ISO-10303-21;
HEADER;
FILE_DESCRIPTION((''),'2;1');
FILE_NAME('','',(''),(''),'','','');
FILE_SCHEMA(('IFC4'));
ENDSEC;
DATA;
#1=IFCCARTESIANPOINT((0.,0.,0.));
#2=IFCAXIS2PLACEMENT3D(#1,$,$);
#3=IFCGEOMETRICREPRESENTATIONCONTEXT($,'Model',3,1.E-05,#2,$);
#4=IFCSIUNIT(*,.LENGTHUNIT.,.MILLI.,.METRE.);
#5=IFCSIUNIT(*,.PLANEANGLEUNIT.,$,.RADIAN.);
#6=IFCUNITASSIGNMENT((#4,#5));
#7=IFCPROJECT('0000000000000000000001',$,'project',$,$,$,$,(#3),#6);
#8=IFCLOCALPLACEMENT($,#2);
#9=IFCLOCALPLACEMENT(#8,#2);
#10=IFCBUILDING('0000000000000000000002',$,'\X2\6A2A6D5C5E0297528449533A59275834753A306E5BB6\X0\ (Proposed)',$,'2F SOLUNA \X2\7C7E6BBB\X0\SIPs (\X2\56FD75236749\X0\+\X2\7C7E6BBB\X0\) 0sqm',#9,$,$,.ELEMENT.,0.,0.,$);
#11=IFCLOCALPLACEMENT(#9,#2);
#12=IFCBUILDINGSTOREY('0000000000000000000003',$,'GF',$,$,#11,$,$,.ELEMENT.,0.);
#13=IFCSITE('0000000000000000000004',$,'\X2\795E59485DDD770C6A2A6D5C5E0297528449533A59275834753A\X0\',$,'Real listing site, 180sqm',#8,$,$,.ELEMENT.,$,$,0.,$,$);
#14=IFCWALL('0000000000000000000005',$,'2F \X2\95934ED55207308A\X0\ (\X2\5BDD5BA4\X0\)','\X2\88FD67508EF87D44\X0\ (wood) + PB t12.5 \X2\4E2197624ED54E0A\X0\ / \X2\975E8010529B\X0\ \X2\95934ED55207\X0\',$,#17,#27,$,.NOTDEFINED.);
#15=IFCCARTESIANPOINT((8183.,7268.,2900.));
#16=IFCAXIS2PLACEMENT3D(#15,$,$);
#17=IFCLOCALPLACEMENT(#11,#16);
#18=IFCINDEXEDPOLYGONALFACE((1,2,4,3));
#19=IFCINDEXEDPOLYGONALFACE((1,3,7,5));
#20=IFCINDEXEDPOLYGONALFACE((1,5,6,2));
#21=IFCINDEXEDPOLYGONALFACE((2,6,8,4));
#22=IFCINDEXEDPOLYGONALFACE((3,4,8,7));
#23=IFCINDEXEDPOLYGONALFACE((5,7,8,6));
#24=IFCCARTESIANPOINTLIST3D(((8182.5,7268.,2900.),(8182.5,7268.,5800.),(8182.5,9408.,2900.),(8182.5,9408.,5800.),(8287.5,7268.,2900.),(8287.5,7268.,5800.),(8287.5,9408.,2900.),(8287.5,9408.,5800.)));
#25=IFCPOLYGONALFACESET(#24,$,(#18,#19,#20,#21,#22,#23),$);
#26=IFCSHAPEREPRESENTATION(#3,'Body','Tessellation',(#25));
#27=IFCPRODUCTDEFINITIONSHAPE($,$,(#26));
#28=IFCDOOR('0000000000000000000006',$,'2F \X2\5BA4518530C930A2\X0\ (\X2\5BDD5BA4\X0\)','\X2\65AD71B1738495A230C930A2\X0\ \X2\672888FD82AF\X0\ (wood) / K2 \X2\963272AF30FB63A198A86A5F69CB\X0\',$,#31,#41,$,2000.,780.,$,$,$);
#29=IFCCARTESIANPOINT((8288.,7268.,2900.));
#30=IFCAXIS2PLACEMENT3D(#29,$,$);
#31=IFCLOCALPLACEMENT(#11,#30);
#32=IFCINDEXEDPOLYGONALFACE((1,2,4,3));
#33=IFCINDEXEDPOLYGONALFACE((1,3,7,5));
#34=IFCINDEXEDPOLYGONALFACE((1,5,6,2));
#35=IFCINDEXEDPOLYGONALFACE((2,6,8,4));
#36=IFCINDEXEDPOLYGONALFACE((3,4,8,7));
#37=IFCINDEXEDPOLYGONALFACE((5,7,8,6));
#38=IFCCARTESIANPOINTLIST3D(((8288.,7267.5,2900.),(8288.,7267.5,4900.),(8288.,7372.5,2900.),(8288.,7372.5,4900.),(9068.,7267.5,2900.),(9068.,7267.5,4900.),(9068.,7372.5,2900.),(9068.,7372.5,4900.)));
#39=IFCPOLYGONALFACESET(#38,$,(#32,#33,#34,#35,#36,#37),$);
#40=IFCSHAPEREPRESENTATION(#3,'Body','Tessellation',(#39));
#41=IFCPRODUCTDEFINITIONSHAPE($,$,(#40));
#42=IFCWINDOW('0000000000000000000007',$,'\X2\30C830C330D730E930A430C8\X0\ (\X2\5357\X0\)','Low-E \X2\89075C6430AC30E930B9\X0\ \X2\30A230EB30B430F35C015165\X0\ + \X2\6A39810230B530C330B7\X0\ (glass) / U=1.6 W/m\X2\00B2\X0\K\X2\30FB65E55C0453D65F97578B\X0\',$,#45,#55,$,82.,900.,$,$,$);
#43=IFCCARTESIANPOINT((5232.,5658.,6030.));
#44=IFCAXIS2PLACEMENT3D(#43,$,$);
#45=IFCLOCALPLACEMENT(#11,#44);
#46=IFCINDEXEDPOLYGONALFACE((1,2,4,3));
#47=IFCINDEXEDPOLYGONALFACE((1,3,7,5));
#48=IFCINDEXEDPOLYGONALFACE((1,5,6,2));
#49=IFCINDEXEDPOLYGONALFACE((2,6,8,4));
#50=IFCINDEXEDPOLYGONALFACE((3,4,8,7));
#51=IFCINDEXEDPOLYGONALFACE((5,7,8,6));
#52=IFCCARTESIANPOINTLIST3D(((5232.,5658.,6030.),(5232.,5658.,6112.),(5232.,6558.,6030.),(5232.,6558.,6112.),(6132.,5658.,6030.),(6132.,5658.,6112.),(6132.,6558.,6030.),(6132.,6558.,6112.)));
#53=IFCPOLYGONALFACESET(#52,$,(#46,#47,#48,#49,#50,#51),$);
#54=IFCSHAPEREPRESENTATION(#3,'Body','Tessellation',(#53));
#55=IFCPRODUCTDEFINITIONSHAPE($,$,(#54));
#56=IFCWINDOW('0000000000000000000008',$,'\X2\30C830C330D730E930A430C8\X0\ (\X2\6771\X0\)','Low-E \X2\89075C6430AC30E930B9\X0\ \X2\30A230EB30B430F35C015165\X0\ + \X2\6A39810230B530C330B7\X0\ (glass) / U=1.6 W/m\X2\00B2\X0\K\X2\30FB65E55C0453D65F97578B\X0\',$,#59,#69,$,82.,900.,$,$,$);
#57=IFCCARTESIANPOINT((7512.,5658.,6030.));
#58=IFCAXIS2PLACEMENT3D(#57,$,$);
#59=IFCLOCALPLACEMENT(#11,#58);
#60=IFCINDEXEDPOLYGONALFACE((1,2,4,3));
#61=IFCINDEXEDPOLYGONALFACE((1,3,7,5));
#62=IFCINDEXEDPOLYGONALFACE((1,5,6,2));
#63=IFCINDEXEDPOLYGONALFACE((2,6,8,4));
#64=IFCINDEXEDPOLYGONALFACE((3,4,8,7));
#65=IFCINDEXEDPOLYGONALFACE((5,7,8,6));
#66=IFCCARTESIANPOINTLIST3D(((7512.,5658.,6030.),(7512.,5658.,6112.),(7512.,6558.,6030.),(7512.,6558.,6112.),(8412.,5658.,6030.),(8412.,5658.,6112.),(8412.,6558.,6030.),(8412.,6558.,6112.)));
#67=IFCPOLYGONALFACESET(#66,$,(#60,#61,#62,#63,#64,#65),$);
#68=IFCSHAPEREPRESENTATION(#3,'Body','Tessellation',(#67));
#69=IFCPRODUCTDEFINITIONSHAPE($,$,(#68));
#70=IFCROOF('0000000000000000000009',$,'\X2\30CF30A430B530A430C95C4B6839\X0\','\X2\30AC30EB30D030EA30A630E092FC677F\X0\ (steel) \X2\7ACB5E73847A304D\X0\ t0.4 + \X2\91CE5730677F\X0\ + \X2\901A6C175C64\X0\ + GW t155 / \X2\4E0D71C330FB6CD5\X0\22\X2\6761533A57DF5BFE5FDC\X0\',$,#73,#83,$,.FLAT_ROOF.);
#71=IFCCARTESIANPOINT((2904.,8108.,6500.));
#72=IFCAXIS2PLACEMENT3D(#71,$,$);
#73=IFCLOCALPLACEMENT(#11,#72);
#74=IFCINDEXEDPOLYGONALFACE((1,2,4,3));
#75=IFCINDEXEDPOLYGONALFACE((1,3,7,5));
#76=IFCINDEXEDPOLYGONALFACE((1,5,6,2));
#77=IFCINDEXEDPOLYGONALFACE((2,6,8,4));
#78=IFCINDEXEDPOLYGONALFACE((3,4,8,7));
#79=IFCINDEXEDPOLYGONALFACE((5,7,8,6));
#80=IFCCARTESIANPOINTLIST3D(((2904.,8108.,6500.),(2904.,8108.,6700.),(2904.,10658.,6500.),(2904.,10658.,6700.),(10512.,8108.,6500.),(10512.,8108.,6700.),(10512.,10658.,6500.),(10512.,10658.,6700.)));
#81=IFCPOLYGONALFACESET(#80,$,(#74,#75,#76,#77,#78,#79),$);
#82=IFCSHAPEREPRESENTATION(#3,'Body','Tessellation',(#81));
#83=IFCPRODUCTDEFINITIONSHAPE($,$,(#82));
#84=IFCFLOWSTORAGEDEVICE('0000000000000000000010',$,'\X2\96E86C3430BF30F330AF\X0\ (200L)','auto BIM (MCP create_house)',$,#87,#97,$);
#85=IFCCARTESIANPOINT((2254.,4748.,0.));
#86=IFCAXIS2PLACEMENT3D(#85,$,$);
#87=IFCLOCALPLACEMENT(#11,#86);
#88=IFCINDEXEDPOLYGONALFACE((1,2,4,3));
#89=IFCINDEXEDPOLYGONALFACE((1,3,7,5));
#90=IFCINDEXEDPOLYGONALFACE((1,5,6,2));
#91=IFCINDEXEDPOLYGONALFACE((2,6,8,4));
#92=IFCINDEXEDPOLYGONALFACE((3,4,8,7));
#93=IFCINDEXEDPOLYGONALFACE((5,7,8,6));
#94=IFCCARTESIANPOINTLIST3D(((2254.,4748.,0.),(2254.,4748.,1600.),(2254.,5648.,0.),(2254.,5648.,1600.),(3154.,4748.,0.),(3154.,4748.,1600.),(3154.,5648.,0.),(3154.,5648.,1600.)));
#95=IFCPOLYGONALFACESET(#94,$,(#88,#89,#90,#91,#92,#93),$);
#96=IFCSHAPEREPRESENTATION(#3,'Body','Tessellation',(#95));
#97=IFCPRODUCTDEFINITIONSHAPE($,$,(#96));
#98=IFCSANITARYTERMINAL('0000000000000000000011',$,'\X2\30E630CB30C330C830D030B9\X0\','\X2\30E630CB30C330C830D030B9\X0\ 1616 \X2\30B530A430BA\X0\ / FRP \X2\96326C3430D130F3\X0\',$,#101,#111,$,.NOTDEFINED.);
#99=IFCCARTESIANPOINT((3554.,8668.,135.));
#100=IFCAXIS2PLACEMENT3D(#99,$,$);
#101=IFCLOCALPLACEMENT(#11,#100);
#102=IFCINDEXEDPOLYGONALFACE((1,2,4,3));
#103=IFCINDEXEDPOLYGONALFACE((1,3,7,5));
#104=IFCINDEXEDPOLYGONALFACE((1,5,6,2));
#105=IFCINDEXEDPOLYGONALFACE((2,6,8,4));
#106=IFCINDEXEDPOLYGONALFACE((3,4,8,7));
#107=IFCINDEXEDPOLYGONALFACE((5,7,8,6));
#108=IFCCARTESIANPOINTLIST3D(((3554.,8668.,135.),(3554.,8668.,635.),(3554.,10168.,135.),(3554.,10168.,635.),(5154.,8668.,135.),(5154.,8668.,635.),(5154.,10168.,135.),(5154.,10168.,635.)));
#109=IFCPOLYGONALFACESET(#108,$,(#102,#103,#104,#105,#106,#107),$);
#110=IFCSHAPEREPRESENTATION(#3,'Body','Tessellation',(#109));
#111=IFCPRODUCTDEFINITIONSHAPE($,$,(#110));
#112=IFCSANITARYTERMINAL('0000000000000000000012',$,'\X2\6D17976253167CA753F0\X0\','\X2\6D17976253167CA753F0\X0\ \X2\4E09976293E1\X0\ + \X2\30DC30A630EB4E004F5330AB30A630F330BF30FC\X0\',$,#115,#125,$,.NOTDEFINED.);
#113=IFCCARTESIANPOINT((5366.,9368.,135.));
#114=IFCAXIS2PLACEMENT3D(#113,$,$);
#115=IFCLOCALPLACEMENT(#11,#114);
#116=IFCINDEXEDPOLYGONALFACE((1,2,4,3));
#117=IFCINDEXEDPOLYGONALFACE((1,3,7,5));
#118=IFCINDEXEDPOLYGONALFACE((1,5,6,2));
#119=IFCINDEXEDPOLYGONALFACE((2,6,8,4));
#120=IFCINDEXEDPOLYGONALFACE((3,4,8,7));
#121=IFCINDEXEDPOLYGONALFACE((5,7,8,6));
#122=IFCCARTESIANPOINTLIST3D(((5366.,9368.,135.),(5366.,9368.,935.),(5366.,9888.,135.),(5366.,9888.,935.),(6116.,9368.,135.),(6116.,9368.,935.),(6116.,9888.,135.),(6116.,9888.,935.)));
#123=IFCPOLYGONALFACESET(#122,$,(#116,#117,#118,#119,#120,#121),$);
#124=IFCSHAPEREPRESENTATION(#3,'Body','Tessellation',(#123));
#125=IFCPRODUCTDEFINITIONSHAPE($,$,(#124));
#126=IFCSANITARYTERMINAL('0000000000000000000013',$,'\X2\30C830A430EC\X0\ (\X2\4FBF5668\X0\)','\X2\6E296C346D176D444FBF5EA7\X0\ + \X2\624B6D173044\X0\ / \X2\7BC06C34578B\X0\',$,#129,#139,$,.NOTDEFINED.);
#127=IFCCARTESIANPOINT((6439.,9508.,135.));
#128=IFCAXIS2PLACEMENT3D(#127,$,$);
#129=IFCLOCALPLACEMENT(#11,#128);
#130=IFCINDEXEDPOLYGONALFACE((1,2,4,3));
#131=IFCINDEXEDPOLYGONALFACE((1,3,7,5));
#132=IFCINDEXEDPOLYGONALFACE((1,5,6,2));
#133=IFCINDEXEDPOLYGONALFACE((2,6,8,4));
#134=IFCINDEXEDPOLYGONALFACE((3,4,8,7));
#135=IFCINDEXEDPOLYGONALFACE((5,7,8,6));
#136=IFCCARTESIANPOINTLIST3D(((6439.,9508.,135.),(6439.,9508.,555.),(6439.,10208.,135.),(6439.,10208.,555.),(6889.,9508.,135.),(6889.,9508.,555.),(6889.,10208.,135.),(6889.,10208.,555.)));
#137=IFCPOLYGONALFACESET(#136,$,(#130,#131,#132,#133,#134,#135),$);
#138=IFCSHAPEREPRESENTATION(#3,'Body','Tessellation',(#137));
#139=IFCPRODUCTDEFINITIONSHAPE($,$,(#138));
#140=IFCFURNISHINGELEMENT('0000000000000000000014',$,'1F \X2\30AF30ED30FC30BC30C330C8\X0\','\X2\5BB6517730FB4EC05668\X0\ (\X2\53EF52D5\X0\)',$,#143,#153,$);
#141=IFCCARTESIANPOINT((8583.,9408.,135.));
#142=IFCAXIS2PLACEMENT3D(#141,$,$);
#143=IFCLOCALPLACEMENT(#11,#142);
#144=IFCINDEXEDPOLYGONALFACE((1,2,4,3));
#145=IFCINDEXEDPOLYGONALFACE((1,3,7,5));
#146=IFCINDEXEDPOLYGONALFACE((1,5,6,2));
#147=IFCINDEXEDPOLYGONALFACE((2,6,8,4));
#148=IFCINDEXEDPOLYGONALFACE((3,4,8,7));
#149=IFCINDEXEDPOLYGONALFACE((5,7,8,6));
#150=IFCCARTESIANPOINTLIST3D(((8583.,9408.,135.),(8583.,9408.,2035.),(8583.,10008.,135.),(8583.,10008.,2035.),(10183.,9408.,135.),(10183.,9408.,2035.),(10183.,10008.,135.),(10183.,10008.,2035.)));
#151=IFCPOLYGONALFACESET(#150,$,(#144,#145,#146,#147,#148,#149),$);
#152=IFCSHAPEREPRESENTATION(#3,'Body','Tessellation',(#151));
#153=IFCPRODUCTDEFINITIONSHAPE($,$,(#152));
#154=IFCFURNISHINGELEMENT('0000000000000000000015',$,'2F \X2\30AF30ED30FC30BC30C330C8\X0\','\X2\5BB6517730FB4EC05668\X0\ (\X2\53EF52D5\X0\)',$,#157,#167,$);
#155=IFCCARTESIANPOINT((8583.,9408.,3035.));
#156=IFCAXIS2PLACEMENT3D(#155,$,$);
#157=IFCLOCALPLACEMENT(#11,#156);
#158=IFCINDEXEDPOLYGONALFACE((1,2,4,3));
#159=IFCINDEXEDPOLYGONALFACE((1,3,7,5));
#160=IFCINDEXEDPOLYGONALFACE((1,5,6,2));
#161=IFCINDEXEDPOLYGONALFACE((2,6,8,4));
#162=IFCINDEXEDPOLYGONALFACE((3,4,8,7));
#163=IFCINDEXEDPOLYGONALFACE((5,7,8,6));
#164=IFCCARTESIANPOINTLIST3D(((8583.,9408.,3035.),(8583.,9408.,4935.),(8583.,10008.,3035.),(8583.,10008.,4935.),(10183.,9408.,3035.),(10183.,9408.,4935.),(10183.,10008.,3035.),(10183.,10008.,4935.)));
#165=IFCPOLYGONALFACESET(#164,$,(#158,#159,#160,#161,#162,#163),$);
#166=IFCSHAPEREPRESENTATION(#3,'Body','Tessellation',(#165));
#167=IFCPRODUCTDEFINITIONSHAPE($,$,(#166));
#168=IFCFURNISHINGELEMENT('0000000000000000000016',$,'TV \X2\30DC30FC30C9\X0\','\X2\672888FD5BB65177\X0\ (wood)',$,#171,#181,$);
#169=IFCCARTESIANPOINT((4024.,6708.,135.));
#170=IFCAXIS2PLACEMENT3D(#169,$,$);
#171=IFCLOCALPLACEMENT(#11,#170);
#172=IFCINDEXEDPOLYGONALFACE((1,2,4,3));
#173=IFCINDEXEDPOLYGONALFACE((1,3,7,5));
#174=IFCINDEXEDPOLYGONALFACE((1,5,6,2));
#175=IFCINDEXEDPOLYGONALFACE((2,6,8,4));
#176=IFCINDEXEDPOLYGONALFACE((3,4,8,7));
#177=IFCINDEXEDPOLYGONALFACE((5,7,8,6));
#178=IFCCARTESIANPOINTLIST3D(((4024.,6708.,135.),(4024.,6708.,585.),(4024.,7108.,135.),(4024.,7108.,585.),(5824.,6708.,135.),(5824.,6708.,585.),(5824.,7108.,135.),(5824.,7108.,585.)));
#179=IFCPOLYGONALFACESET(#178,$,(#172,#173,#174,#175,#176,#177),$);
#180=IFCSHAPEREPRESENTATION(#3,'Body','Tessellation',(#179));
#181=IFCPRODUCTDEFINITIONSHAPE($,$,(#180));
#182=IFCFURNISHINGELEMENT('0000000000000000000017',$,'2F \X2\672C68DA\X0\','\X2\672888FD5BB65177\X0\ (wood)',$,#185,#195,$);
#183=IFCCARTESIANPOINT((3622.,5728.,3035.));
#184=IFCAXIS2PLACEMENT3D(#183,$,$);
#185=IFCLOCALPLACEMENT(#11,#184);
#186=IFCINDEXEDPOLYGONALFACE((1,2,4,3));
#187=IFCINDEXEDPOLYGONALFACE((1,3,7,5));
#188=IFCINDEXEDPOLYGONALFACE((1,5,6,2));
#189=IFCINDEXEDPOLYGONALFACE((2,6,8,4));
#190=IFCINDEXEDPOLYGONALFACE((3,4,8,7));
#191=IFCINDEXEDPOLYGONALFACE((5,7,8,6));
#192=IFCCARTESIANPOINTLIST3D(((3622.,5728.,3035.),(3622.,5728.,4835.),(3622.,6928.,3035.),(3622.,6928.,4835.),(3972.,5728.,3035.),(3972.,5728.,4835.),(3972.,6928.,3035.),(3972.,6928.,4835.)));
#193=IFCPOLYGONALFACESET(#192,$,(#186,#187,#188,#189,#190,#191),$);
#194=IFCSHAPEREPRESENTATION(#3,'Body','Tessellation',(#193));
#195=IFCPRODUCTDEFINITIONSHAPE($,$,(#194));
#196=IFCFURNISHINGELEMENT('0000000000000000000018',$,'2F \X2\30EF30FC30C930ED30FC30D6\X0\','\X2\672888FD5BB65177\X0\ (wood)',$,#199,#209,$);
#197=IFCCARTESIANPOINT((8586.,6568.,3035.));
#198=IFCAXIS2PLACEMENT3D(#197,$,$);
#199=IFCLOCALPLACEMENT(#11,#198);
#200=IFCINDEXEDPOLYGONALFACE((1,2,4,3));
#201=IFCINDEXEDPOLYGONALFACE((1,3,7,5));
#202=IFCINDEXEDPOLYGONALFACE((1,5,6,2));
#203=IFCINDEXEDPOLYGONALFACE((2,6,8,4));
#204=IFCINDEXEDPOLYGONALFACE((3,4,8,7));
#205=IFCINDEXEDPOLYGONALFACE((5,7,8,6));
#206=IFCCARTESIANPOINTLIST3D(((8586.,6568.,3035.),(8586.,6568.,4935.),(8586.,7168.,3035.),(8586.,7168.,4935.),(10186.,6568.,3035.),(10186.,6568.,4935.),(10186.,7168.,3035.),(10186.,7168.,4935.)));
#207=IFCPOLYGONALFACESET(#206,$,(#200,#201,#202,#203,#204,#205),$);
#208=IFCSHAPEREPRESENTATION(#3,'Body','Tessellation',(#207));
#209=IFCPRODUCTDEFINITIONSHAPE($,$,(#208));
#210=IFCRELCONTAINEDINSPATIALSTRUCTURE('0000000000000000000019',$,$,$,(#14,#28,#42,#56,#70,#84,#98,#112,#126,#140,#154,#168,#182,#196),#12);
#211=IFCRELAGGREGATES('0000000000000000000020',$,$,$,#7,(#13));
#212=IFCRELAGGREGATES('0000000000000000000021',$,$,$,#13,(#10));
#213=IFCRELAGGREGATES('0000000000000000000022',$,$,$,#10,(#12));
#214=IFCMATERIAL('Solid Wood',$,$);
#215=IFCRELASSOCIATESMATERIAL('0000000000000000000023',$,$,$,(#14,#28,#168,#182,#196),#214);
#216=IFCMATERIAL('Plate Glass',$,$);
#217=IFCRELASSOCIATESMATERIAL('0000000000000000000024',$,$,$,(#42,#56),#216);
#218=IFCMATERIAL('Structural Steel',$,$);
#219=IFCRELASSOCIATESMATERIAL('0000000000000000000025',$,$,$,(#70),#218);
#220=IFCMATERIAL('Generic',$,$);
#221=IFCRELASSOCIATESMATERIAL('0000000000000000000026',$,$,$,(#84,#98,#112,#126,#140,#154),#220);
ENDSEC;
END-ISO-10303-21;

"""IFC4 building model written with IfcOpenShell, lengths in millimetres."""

from ifc_helpers import new_model, si_unit, frame, frame_2d, origin, place, context, project, spatial, rectangle, extrude, material, element, save


model = new_model("IFC4")

# Units and contexts
model_context = context("Model", 3, precision=1e-05, world=origin())
ifc_project = project(units=[si_unit("LENGTHUNIT", "METRE", prefix="MILLI"), si_unit("PLANEANGLEUNIT", "RADIAN")], contexts=[model_context])

# Site, building, storey
site_placement = place(None, origin())
site = spatial("IfcSite", under=ifc_project, at=site_placement, Name="神奈川県横浜市青葉区大場町", ObjectType="Real listing site, 180sqm", CompositionType="ELEMENT", RefElevation=0.0)
building_placement = place(site_placement, origin())
building = spatial("IfcBuilding", under=site, at=building_placement, Name="横浜市青葉区大場町の家 (Proposed)", ObjectType="2F SOLUNA 籾殻SIPs (国産杉+籾殻) 0sqm", CompositionType="ELEMENT", ElevationOfRefHeight=0.0, ElevationOfTerrain=0.0)
storey_placement = place(building_placement, origin())
storey = spatial("IfcBuildingStorey", under=building, at=storey_placement, Name="GF", CompositionType="ELEMENT", Elevation=0.0)

# Shared definitions
ifc_material_1 = material(Name="Solid Wood")
ifc_material_2 = material(Name="Plate Glass")

# Wall
wall_1_placement = place(storey_placement, frame((8183.0, 7268.0, 2900.0)))
element("IfcWall", 1, at=wall_1_placement, inside=storey, material=ifc_material_1, Name="2F 間仕切り (寝室)", Description="製材軸組 (wood) + PB t12.5 両面仕上 / 非耐力 間仕切", PredefinedType="NOTDEFINED", context=model_context, shape_type="SweptSolid", body=[
    extrude(rectangle(XDim=105.0, YDim=2140.0, at=frame_2d((52.0, 1070.0))), frame((8183.0, 7268.0, 2900.0)), (0.0, 0.0, 1.0), 2900.0),
])

# Door
door_1_placement = place(storey_placement, frame((8288.0, 7268.0, 2900.0)))
element("IfcDoor", 2, at=door_1_placement, inside=storey, material=ifc_material_1, Name="2F 室内ドア (寝室)", Description="断熱玄関ドア 木製芯 (wood) / K2 防犯・採風機構", OverallHeight=2000.0, OverallWidth=780.0, context=model_context, shape_type="SweptSolid", body=[
    extrude(rectangle(XDim=780.0, YDim=105.0, at=frame_2d((390.0, 52.0))), frame((8288.0, 7268.0, 2900.0)), (0.0, 0.0, 1.0), 2000.0),
])

# Windows
window_1_placement = place(storey_placement, frame((5232.0, 5658.0, 6030.0)))
element("IfcWindow", 3, at=window_1_placement, inside=storey, material=ifc_material_2, Name="トップライト (南)", Description="Low-E 複層ガラス アルゴン封入 + 樹脂サッシ (glass) / U=1.6 W/m²K・日射取得型", OverallHeight=82.0, OverallWidth=900.0, context=model_context, shape_type="SweptSolid", body=[
    extrude(rectangle(XDim=900.0, YDim=900.0, at=frame_2d((450.0, 450.0))), frame((5232.0, 5658.0, 6030.0)), (0.0, 0.0, 1.0), 82.0),
])
window_2_placement = place(storey_placement, frame((7512.0, 5658.0, 6030.0)))
element("IfcWindow", 4, at=window_2_placement, inside=storey, material=ifc_material_2, Name="トップライト (東)", Description="Low-E 複層ガラス アルゴン封入 + 樹脂サッシ (glass) / U=1.6 W/m²K・日射取得型", OverallHeight=82.0, OverallWidth=900.0, context=model_context, shape_type="SweptSolid", body=[
    extrude(rectangle(XDim=900.0, YDim=900.0, at=frame_2d((450.0, 450.0))), frame((7512.0, 5658.0, 6030.0)), (0.0, 0.0, 1.0), 82.0),
])

# Roof
ifc_material_3 = material(Name="Structural Steel")
roof_placement = place(storey_placement, frame((2904.0, 8108.0, 6500.0)))
element("IfcRoof", 5, at=roof_placement, inside=storey, material=ifc_material_3, Name="ハイサイド屋根", Description="ガルバリウム鋼板 (steel) 立平葺き t0.4 + 野地板 + 通気層 + GW t155 / 不燃・法22条区域対応", PredefinedType="FLAT_ROOF", context=model_context, shape_type="SweptSolid", body=[
    extrude(rectangle(XDim=7608.0, YDim=2550.0, at=frame_2d((3804.0, 1275.0))), frame((2904.0, 8108.0, 6500.0)), (0.0, 0.0, 1.0), 200.0),
])

# Flow storage device
ifc_material_4 = material(Name="Generic")
flow_storage_device_placement = place(storey_placement, frame((2254.0, 4748.0, 0.0)))
element("IfcFlowStorageDevice", 6, at=flow_storage_device_placement, inside=storey, material=ifc_material_4, Name="雨水タンク (200L)", Description="auto BIM (MCP create_house)", context=model_context, shape_type="SweptSolid", body=[
    extrude(rectangle(XDim=900.0, YDim=900.0, at=frame_2d((450.0, 450.0))), frame((2254.0, 4748.0, 0.0)), (0.0, 0.0, 1.0), 1600.0),
])

# Sanitary terminals
sanitary_terminal_1_placement = place(storey_placement, frame((3554.0, 8668.0, 135.0)))
element("IfcSanitaryTerminal", 7, at=sanitary_terminal_1_placement, inside=storey, material=ifc_material_4, Name="ユニットバス", Description="ユニットバス 1616 サイズ / FRP 防水パン", PredefinedType="NOTDEFINED", context=model_context, shape_type="SweptSolid", body=[
    extrude(rectangle(XDim=1600.0, YDim=1500.0, at=frame_2d((800.0, 750.0))), frame((3554.0, 8668.0, 135.0)), (0.0, 0.0, 1.0), 500.0),
])
sanitary_terminal_2_placement = place(storey_placement, frame((5366.0, 9368.0, 135.0)))
element("IfcSanitaryTerminal", 8, at=sanitary_terminal_2_placement, inside=storey, material=ifc_material_4, Name="洗面化粧台", Description="洗面化粧台 三面鏡 + ボウル一体カウンター", PredefinedType="NOTDEFINED", context=model_context, shape_type="SweptSolid", body=[
    extrude(rectangle(XDim=750.0, YDim=520.0, at=frame_2d((375.0, 260.0))), frame((5366.0, 9368.0, 135.0)), (0.0, 0.0, 1.0), 800.0),
])
sanitary_terminal_3_placement = place(storey_placement, frame((6439.0, 9508.0, 135.0)))
element("IfcSanitaryTerminal", 9, at=sanitary_terminal_3_placement, inside=storey, material=ifc_material_4, Name="トイレ (便器)", Description="温水洗浄便座 + 手洗い / 節水型", PredefinedType="NOTDEFINED", context=model_context, shape_type="SweptSolid", body=[
    extrude(rectangle(XDim=450.0, YDim=700.0, at=frame_2d((225.0, 350.0))), frame((6439.0, 9508.0, 135.0)), (0.0, 0.0, 1.0), 420.0),
])

# Furnishing elements
furnishing_1_placement = place(storey_placement, frame((8583.0, 9408.0, 135.0)))
element("IfcFurnishingElement", 10, at=furnishing_1_placement, inside=storey, material=ifc_material_4, Name="1F クローゼット", Description="家具・什器 (可動)", context=model_context, shape_type="SweptSolid", body=[
    extrude(rectangle(XDim=1600.0, YDim=600.0, at=frame_2d((800.0, 300.0))), frame((8583.0, 9408.0, 135.0)), (0.0, 0.0, 1.0), 1900.0),
])
furnishing_2_placement = place(storey_placement, frame((8583.0, 9408.0, 3035.0)))
element("IfcFurnishingElement", 11, at=furnishing_2_placement, inside=storey, material=ifc_material_4, Name="2F クローゼット", Description="家具・什器 (可動)", context=model_context, shape_type="SweptSolid", body=[
    extrude(rectangle(XDim=1600.0, YDim=600.0, at=frame_2d((800.0, 300.0))), frame((8583.0, 9408.0, 3035.0)), (0.0, 0.0, 1.0), 1900.0),
])
furnishing_3_placement = place(storey_placement, frame((4024.0, 6708.0, 135.0)))
element("IfcFurnishingElement", 12, at=furnishing_3_placement, inside=storey, material=ifc_material_1, Name="TV ボード", Description="木製家具 (wood)", context=model_context, shape_type="SweptSolid", body=[
    extrude(rectangle(XDim=1800.0, YDim=400.0, at=frame_2d((900.0, 200.0))), frame((4024.0, 6708.0, 135.0)), (0.0, 0.0, 1.0), 450.0),
])
furnishing_4_placement = place(storey_placement, frame((3622.0, 5728.0, 3035.0)))
element("IfcFurnishingElement", 13, at=furnishing_4_placement, inside=storey, material=ifc_material_1, Name="2F 本棚", Description="木製家具 (wood)", context=model_context, shape_type="SweptSolid", body=[
    extrude(rectangle(XDim=350.0, YDim=1200.0, at=frame_2d((175.0, 600.0))), frame((3622.0, 5728.0, 3035.0)), (0.0, 0.0, 1.0), 1800.0),
])
furnishing_5_placement = place(storey_placement, frame((8586.0, 6568.0, 3035.0)))
element("IfcFurnishingElement", 14, at=furnishing_5_placement, inside=storey, material=ifc_material_1, Name="2F ワードローブ", Description="木製家具 (wood)", context=model_context, shape_type="SweptSolid", body=[
    extrude(rectangle(XDim=1600.0, YDim=600.0, at=frame_2d((800.0, 300.0))), frame((8586.0, 6568.0, 3035.0)), (0.0, 0.0, 1.0), 1900.0),
])

save(model, "model.ifc")
